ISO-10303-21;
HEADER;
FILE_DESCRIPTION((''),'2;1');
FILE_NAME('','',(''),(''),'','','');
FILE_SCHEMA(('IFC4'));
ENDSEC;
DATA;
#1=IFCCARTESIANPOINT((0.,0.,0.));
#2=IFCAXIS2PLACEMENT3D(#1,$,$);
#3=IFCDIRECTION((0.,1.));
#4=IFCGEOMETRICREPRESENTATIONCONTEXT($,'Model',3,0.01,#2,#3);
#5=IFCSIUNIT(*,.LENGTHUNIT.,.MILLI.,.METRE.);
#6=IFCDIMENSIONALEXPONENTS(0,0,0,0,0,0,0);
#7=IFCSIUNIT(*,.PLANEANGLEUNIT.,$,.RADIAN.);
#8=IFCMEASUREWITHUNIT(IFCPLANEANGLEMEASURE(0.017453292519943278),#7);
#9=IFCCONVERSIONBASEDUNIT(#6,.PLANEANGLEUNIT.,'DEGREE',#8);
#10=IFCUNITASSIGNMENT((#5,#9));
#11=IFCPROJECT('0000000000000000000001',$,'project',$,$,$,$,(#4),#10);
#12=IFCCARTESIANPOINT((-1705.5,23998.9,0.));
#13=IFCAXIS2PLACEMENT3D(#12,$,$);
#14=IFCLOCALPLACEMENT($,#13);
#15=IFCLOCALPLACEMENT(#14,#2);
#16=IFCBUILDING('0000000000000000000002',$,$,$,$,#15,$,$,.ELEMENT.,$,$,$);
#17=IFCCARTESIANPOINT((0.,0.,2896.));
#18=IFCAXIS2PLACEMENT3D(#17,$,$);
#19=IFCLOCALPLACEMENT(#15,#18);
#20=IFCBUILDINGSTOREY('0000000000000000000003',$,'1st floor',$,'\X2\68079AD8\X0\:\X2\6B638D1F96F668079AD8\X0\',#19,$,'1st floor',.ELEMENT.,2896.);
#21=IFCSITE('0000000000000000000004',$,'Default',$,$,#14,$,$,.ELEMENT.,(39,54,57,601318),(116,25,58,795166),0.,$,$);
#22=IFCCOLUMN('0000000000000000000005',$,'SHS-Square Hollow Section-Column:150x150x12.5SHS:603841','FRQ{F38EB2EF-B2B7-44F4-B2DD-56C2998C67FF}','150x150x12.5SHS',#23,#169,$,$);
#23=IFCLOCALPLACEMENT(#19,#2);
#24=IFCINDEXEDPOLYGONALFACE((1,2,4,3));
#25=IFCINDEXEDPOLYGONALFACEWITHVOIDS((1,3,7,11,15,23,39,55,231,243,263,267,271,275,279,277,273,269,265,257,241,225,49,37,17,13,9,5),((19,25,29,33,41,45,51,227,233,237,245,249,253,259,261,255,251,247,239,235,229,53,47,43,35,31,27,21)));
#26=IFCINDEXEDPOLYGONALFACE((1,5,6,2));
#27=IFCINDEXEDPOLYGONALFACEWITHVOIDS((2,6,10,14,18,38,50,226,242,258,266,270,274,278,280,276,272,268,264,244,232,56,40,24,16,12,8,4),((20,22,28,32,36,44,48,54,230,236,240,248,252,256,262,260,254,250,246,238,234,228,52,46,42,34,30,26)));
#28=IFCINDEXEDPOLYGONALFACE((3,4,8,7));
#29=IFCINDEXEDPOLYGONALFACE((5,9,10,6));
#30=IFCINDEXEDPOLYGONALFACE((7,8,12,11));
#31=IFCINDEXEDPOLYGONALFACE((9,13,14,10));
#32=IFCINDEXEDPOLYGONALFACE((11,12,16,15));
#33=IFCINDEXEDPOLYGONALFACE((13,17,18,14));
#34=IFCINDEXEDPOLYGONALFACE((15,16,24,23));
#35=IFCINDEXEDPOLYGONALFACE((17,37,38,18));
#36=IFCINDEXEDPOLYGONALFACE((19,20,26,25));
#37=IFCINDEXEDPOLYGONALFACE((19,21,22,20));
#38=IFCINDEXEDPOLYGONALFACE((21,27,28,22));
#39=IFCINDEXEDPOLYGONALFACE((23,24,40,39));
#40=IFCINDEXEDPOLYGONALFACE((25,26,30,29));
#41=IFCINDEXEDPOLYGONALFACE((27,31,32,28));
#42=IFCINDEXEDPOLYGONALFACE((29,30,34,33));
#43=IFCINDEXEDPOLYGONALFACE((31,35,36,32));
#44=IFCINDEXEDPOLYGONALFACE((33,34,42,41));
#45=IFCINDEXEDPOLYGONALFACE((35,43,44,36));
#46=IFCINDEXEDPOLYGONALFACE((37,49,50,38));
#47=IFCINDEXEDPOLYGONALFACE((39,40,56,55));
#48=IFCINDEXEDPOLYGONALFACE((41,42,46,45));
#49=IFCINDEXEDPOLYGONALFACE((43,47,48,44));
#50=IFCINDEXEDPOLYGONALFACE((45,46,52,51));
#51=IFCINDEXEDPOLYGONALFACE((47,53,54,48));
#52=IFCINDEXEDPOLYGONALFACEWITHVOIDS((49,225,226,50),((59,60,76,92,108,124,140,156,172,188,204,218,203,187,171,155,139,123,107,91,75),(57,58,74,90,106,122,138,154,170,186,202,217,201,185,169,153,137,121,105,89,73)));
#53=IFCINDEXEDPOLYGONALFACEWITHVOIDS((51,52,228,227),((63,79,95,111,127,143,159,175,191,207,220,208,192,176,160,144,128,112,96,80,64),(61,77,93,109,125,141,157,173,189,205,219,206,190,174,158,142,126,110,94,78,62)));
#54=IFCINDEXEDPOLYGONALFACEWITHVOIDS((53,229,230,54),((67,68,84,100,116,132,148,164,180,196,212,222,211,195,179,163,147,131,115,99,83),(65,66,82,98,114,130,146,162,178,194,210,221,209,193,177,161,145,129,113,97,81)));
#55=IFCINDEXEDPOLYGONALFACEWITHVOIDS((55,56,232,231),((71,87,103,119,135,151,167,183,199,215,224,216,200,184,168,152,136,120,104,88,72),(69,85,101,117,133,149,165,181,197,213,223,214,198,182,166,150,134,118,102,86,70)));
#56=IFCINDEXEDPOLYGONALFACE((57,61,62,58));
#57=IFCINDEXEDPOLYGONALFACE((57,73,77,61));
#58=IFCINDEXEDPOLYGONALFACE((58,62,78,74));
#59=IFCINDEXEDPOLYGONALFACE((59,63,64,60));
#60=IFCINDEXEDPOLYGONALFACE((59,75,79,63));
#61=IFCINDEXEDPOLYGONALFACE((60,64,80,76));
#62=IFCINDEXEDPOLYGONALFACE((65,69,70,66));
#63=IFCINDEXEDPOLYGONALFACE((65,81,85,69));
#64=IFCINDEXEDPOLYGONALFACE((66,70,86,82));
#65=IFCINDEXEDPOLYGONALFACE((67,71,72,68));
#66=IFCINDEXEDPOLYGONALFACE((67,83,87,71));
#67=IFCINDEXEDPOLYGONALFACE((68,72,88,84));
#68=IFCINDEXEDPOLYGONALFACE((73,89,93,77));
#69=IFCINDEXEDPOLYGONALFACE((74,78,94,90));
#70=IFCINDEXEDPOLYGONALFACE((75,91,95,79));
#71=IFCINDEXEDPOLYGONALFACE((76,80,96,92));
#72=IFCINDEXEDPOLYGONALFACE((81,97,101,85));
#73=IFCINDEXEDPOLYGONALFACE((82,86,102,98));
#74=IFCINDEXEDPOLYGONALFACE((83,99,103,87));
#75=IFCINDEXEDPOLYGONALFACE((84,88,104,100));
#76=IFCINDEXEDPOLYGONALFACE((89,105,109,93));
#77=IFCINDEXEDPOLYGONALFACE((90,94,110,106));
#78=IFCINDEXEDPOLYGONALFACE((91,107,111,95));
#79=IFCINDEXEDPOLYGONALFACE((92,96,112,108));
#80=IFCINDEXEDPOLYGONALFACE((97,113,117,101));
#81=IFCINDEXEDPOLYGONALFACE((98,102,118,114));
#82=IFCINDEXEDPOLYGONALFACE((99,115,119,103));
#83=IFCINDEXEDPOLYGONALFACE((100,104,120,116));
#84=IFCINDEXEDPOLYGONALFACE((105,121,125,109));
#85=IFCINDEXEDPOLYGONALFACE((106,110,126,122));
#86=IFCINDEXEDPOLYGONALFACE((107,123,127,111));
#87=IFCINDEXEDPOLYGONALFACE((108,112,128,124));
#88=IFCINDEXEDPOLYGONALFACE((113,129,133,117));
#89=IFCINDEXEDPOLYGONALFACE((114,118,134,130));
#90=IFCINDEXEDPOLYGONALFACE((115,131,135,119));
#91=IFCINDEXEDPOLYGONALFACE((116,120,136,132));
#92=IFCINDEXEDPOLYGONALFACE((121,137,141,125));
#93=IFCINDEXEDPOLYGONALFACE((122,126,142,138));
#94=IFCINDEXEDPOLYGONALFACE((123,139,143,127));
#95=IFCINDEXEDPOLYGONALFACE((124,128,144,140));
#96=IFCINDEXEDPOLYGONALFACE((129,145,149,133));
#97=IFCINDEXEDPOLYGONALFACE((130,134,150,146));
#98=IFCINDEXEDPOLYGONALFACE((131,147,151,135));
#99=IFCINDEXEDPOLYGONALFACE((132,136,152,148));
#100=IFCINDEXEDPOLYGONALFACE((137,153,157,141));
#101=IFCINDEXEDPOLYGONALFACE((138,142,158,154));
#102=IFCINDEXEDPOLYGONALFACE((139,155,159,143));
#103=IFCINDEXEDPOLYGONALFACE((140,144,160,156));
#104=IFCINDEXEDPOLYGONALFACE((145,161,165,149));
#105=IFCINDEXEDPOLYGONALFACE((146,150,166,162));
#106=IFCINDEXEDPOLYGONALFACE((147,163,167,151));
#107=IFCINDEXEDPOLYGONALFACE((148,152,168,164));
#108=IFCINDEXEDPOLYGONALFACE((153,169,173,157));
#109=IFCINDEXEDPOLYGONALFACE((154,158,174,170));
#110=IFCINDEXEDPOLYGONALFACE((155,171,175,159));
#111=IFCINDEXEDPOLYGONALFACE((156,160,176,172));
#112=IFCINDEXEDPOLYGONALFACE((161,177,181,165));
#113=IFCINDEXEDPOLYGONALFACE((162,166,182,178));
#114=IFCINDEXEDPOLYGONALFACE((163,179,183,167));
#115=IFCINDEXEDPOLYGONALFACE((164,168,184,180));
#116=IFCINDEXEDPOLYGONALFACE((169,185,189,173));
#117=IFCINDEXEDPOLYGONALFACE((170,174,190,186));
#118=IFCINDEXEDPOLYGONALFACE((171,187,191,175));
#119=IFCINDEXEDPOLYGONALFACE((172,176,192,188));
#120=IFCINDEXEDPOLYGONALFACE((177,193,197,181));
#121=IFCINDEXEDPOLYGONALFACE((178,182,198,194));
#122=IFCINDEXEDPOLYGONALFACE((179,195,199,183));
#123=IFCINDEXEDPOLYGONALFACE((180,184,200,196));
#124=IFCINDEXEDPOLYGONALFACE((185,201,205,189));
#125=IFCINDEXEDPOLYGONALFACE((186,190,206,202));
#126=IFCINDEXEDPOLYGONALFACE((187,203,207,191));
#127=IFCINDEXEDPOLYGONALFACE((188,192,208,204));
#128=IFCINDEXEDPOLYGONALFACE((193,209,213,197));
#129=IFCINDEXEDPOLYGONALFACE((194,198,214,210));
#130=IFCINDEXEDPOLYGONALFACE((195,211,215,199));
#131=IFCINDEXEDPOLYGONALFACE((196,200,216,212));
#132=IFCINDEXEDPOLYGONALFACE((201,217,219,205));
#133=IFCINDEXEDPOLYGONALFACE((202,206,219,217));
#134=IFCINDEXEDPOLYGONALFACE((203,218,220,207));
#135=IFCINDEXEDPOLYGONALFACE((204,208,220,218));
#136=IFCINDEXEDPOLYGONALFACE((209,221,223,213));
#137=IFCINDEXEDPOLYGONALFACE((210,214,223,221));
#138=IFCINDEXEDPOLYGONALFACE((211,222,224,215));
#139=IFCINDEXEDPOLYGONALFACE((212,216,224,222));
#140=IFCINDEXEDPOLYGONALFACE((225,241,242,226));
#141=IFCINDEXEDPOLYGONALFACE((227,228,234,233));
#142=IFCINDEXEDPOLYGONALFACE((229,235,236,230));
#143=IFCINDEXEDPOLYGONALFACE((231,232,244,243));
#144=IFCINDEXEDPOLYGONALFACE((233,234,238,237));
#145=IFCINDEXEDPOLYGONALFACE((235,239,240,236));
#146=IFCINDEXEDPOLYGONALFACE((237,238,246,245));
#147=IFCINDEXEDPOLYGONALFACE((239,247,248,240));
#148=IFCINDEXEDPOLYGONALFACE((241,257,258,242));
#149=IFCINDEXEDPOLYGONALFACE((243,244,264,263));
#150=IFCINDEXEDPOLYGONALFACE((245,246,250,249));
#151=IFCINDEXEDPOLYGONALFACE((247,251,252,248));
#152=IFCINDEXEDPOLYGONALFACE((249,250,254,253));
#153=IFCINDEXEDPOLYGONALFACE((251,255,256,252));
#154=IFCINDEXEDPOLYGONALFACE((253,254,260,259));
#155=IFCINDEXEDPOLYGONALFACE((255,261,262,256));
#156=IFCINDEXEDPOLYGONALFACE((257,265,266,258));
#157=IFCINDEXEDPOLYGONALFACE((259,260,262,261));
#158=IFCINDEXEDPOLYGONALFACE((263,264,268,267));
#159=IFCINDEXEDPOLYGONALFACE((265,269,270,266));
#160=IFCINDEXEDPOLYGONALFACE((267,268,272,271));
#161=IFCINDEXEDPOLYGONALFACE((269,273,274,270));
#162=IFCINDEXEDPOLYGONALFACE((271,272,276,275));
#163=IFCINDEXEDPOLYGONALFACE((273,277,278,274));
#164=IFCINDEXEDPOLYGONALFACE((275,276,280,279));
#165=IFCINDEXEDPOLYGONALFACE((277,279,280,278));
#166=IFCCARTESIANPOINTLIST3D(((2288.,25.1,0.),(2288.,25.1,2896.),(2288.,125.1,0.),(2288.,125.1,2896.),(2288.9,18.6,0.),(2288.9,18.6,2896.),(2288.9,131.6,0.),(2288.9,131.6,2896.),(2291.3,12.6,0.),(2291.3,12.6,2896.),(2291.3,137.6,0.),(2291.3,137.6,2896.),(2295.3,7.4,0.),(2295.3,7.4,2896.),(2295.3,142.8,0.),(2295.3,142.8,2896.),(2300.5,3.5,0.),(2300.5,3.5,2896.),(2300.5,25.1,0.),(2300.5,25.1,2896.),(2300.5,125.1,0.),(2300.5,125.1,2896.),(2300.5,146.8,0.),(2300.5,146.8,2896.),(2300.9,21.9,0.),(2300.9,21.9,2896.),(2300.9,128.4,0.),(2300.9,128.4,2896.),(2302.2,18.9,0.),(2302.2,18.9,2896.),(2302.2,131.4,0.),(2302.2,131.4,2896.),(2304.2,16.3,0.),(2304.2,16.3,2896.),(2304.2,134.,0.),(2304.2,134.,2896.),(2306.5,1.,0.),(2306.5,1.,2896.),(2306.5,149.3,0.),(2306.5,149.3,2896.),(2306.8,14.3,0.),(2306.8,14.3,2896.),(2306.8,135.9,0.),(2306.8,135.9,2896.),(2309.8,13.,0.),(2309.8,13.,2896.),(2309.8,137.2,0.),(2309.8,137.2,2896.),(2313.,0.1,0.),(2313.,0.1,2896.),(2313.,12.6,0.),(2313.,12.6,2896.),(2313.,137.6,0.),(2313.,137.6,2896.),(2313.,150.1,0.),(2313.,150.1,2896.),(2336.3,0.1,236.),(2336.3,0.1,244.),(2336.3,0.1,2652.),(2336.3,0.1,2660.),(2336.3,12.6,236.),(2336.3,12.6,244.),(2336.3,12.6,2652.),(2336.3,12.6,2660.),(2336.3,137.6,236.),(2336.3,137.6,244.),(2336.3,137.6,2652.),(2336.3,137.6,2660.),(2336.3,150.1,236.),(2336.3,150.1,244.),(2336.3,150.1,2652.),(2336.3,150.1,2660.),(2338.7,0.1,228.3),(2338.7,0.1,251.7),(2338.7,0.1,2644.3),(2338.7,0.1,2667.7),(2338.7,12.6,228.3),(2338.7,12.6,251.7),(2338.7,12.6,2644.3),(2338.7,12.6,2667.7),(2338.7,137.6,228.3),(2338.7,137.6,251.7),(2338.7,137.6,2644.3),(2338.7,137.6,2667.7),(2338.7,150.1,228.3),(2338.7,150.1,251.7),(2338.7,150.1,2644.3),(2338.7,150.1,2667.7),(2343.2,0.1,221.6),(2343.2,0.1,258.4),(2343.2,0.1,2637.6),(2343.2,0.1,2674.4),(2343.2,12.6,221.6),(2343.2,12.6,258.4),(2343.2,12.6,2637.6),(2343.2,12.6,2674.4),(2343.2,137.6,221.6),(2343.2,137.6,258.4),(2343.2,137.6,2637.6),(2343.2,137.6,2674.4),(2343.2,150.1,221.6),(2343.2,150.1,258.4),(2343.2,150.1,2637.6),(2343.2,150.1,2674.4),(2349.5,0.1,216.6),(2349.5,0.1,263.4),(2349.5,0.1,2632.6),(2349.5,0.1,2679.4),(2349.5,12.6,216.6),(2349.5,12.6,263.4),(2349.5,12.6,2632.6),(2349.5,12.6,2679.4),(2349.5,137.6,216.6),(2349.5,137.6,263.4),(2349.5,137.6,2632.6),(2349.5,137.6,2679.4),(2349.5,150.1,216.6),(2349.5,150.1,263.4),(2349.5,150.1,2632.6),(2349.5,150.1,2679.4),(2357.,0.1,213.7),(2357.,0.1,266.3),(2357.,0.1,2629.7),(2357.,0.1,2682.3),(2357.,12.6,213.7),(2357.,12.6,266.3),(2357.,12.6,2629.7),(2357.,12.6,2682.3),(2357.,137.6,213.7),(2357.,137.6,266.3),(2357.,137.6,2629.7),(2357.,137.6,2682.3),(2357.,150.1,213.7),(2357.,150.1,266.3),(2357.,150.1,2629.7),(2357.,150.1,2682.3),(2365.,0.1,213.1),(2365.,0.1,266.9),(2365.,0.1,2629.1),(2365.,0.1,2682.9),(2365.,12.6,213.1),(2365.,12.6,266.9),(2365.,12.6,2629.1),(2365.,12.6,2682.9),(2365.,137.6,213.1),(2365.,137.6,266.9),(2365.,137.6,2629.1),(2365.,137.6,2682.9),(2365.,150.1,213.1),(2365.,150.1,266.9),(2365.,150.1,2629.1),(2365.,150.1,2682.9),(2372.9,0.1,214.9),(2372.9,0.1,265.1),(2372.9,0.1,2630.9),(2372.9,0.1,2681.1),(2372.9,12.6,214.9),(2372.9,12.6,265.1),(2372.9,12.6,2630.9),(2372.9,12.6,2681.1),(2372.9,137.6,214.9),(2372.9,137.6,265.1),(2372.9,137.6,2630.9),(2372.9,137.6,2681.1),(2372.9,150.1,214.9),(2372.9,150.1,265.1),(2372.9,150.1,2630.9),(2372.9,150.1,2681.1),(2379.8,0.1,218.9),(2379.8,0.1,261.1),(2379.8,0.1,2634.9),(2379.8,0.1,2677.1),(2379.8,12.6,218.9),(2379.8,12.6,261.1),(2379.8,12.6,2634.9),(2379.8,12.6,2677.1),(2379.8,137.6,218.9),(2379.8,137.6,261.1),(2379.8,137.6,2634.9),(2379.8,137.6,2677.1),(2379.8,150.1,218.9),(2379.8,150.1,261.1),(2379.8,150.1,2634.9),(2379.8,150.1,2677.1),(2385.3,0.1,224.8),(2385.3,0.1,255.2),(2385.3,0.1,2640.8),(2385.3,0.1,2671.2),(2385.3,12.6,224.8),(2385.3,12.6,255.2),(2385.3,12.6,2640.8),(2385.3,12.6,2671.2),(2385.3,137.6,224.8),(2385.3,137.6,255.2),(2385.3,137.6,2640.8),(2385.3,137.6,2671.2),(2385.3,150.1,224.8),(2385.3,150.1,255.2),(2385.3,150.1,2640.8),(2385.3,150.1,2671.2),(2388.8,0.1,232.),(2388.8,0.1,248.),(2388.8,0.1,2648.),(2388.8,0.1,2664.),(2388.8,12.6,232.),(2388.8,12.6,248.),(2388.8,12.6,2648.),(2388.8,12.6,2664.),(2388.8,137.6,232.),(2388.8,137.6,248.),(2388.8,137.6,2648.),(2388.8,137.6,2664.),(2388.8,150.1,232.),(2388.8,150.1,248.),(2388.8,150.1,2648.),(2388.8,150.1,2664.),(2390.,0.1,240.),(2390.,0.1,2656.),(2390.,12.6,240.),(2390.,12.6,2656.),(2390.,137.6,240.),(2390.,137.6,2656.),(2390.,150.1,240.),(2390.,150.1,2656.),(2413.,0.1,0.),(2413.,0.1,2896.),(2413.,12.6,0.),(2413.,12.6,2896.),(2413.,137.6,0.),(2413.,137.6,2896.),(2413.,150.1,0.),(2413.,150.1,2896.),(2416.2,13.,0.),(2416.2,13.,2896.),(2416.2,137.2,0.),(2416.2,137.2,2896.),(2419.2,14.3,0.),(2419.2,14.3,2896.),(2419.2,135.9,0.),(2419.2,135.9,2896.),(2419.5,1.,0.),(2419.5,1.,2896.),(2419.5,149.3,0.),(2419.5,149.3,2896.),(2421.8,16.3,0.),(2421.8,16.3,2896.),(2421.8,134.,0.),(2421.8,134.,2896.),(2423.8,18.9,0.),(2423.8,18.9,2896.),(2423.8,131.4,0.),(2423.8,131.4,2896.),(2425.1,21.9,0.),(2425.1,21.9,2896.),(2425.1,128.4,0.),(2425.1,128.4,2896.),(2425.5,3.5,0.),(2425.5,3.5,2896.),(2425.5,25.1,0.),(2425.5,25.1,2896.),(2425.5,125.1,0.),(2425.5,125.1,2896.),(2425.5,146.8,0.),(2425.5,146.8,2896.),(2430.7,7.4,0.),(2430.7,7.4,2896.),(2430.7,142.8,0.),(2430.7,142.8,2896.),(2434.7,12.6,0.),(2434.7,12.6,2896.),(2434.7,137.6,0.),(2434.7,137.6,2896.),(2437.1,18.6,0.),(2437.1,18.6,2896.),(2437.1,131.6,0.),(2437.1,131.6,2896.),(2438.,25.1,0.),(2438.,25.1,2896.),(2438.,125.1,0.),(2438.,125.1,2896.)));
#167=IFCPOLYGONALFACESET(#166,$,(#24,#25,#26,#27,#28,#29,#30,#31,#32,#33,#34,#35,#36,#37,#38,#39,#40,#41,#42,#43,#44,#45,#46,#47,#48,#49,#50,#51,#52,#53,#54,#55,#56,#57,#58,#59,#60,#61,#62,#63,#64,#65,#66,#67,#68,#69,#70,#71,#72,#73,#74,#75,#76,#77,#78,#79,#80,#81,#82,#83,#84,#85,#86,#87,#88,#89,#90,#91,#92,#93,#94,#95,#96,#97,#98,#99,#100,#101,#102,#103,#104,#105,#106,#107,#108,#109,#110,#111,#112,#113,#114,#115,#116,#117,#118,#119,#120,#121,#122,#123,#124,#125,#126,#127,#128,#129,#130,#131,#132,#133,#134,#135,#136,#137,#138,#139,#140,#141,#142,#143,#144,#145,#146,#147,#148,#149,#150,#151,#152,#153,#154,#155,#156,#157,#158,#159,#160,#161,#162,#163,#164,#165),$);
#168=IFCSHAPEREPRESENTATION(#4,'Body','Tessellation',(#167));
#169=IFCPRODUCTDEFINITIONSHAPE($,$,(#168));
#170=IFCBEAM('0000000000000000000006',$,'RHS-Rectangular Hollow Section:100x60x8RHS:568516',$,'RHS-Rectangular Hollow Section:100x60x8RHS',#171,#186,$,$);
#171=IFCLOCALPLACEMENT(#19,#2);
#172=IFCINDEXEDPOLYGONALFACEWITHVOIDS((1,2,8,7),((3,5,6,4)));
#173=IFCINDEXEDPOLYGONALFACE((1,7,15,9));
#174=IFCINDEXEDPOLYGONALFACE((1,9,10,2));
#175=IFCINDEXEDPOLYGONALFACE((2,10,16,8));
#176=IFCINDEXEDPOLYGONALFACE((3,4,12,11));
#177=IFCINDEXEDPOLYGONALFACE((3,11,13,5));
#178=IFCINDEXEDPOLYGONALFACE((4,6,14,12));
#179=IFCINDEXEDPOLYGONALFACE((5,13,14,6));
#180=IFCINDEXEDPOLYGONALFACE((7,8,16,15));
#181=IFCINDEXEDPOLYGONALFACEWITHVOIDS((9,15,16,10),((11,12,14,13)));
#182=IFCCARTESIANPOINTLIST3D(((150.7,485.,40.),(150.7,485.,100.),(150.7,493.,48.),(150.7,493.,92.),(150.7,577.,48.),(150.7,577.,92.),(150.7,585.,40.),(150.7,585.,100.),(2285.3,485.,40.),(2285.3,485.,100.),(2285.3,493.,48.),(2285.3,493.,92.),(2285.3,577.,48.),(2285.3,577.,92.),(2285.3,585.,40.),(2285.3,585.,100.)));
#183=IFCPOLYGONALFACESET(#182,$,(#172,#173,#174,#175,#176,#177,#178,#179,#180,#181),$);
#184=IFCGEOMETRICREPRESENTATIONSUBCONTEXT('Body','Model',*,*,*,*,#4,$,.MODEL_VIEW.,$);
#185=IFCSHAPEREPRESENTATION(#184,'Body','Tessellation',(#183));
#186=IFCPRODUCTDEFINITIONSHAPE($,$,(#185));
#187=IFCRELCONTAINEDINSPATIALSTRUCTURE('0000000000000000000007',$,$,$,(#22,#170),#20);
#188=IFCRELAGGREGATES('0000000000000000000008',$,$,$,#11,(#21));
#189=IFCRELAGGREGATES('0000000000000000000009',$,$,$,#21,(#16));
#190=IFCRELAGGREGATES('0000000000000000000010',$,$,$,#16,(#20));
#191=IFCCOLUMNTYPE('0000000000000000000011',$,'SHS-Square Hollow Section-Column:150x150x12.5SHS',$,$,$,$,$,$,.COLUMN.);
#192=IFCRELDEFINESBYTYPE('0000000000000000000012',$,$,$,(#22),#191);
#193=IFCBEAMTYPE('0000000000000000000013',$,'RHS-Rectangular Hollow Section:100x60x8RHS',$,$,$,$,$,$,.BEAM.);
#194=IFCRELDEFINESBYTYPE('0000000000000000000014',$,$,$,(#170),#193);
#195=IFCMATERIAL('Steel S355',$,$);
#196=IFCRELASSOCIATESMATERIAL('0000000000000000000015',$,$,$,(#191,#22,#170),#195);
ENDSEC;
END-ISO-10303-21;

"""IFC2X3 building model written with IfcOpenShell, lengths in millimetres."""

from ifc_helpers import new_model, entity, si_unit, converted_unit, direction, frame, frame_2d, origin, origin_2d, place, context, subcontext, project, spatial, circle_curve, rectangle, hollow_rectangle, outline, extrude, boolean, material, type_object, element, save


model = new_model("IFC2X3")

# Units and contexts
model_context = context("Model", 3, precision=0.01, world=origin(), true_north=direction((0.0, 1.0)))
body_context = subcontext(model_context, "Body", "Model", "MODEL_VIEW")
ifc_project = project(units=[si_unit("LENGTHUNIT", "METRE", prefix="MILLI"), converted_unit("PLANEANGLEUNIT", "DEGREE", entity("IfcPlaneAngleMeasure", 0.017453292519943278), si_unit("PLANEANGLEUNIT", "RADIAN"), dimensions=[0, 0, 0, 0, 0, 0, 0])], contexts=[model_context])

# Site, building, storey
site_placement = place(None, frame((-1705.5, 23998.9, 0.0)))
site = spatial("IfcSite", under=ifc_project, at=site_placement, Name="Default", CompositionType="ELEMENT", RefLatitude=(39, 54, 57, 601318), RefLongitude=(116, 25, 58, 795166), RefElevation=0.0)
building_placement = place(site_placement, origin())
building = spatial("IfcBuilding", under=site, at=building_placement, CompositionType="ELEMENT")
storey_placement = place(building_placement, frame((0.0, 0.0, 2896.0)))
storey = spatial("IfcBuildingStorey", under=building, at=storey_placement, Name="1st floor", ObjectType="标高:正负零标高", LongName="1st floor", CompositionType="ELEMENT", Elevation=2896.0)

# Shared definitions
ifc_material_1 = material(Name="Steel S355")

# Column, openings
column_type_1 = type_object("IfcColumnType", Name="SHS-Square Hollow Section-Column:150x150x12.5SHS", PredefinedType="COLUMN", material=ifc_material_1)
column_1_placement = place(storey_placement, frame((2363.0, 75.1, 2896.0), z_axis=(0.0, 0.0, 1.0), x_axis=(0.0, 1.0, 0.0)))
column_1 = element("IfcColumn", 1, at=column_1_placement, inside=storey, type_object=column_type_1, material=ifc_material_1, Name="SHS-Square Hollow Section-Column:150x150x12.5SHS:603841", Description="FRQ{F38EB2EF-B2B7-44F4-B2DD-56C2998C67FF}", ObjectType="150x150x12.5SHS", context=model_context, shape_type="SweptSolid", body=[
    extrude(hollow_rectangle(XDim=150.0, YDim=150.0, WallThickness=12.5, InnerFilletRadius=12.5, OuterFilletRadius=25.0, at=origin_2d()), origin(), (0.0, 0.0, -1.0), 2896.0),
])
opening_1_placement = place(column_1_placement, frame((175.1, 0.0, 0.0), z_axis=(-1.0, 0.0, 0.0), x_axis=(0.0, -1.0, 0.0)))
element("IfcOpeningElement", 2, at=opening_1_placement, cuts=column_1, ObjectType="Opening", context=model_context, shape_type="SweptSolid", body=[
    extrude(outline(circle_curve(frame_2d((0.0, -240.0), x_axis=(1.0, 0.0)), 27.0)), origin(), (0.0, 0.0, 1.0), 350.2),
])
opening_2_placement = place(column_1_placement, frame((175.1, 0.0, -2896.0), z_axis=(-1.0, 0.0, 0.0), x_axis=(0.0, -1.0, 0.0)))
element("IfcOpeningElement", 3, at=opening_2_placement, cuts=column_1, ObjectType="Opening", context=model_context, shape_type="SweptSolid", body=[
    extrude(outline(circle_curve(frame_2d((0.0, 240.0), x_axis=(1.0, 0.0)), 27.0)), origin(), (0.0, 0.0, 1.0), 350.2),
])

# Beam
beam_type_1 = type_object("IfcBeamType", Name="RHS-Rectangular Hollow Section:100x60x8RHS", PredefinedType="BEAM")
beam_1_placement = place(storey_placement, frame((150.7, 585.0, 70.0)))
element("IfcBeam", 4, at=beam_1_placement, inside=storey, type_object=beam_type_1, material=ifc_material_1, Name="RHS-Rectangular Hollow Section:100x60x8RHS:568516", ObjectType="RHS-Rectangular Hollow Section:100x60x8RHS", context=body_context, shape_type="SweptSolid", body=[
    boolean("DIFFERENCE", extrude(rectangle(XDim=60.0, YDim=100.0, at=frame_2d((0.0, 0.0), x_axis=(1.0, 0.0))), frame((0.0, -50.0, 0.0), z_axis=(1.0, 0.0, 0.0), x_axis=(0.0, 0.0, -1.0)), (0.0, 0.0, 1.0), 2134.6), extrude(rectangle(XDim=44.0, YDim=84.0, at=frame_2d((0.0, 0.0), x_axis=(0.0, 1.0))), frame((2134.6, -50.0, 0.0), z_axis=(-1.0, 0.0, 0.0), x_axis=(0.0, 1.0, 0.0)), (0.0, 0.0, 1.0), 2134.6)),
])

save(model, "model.ifc")
